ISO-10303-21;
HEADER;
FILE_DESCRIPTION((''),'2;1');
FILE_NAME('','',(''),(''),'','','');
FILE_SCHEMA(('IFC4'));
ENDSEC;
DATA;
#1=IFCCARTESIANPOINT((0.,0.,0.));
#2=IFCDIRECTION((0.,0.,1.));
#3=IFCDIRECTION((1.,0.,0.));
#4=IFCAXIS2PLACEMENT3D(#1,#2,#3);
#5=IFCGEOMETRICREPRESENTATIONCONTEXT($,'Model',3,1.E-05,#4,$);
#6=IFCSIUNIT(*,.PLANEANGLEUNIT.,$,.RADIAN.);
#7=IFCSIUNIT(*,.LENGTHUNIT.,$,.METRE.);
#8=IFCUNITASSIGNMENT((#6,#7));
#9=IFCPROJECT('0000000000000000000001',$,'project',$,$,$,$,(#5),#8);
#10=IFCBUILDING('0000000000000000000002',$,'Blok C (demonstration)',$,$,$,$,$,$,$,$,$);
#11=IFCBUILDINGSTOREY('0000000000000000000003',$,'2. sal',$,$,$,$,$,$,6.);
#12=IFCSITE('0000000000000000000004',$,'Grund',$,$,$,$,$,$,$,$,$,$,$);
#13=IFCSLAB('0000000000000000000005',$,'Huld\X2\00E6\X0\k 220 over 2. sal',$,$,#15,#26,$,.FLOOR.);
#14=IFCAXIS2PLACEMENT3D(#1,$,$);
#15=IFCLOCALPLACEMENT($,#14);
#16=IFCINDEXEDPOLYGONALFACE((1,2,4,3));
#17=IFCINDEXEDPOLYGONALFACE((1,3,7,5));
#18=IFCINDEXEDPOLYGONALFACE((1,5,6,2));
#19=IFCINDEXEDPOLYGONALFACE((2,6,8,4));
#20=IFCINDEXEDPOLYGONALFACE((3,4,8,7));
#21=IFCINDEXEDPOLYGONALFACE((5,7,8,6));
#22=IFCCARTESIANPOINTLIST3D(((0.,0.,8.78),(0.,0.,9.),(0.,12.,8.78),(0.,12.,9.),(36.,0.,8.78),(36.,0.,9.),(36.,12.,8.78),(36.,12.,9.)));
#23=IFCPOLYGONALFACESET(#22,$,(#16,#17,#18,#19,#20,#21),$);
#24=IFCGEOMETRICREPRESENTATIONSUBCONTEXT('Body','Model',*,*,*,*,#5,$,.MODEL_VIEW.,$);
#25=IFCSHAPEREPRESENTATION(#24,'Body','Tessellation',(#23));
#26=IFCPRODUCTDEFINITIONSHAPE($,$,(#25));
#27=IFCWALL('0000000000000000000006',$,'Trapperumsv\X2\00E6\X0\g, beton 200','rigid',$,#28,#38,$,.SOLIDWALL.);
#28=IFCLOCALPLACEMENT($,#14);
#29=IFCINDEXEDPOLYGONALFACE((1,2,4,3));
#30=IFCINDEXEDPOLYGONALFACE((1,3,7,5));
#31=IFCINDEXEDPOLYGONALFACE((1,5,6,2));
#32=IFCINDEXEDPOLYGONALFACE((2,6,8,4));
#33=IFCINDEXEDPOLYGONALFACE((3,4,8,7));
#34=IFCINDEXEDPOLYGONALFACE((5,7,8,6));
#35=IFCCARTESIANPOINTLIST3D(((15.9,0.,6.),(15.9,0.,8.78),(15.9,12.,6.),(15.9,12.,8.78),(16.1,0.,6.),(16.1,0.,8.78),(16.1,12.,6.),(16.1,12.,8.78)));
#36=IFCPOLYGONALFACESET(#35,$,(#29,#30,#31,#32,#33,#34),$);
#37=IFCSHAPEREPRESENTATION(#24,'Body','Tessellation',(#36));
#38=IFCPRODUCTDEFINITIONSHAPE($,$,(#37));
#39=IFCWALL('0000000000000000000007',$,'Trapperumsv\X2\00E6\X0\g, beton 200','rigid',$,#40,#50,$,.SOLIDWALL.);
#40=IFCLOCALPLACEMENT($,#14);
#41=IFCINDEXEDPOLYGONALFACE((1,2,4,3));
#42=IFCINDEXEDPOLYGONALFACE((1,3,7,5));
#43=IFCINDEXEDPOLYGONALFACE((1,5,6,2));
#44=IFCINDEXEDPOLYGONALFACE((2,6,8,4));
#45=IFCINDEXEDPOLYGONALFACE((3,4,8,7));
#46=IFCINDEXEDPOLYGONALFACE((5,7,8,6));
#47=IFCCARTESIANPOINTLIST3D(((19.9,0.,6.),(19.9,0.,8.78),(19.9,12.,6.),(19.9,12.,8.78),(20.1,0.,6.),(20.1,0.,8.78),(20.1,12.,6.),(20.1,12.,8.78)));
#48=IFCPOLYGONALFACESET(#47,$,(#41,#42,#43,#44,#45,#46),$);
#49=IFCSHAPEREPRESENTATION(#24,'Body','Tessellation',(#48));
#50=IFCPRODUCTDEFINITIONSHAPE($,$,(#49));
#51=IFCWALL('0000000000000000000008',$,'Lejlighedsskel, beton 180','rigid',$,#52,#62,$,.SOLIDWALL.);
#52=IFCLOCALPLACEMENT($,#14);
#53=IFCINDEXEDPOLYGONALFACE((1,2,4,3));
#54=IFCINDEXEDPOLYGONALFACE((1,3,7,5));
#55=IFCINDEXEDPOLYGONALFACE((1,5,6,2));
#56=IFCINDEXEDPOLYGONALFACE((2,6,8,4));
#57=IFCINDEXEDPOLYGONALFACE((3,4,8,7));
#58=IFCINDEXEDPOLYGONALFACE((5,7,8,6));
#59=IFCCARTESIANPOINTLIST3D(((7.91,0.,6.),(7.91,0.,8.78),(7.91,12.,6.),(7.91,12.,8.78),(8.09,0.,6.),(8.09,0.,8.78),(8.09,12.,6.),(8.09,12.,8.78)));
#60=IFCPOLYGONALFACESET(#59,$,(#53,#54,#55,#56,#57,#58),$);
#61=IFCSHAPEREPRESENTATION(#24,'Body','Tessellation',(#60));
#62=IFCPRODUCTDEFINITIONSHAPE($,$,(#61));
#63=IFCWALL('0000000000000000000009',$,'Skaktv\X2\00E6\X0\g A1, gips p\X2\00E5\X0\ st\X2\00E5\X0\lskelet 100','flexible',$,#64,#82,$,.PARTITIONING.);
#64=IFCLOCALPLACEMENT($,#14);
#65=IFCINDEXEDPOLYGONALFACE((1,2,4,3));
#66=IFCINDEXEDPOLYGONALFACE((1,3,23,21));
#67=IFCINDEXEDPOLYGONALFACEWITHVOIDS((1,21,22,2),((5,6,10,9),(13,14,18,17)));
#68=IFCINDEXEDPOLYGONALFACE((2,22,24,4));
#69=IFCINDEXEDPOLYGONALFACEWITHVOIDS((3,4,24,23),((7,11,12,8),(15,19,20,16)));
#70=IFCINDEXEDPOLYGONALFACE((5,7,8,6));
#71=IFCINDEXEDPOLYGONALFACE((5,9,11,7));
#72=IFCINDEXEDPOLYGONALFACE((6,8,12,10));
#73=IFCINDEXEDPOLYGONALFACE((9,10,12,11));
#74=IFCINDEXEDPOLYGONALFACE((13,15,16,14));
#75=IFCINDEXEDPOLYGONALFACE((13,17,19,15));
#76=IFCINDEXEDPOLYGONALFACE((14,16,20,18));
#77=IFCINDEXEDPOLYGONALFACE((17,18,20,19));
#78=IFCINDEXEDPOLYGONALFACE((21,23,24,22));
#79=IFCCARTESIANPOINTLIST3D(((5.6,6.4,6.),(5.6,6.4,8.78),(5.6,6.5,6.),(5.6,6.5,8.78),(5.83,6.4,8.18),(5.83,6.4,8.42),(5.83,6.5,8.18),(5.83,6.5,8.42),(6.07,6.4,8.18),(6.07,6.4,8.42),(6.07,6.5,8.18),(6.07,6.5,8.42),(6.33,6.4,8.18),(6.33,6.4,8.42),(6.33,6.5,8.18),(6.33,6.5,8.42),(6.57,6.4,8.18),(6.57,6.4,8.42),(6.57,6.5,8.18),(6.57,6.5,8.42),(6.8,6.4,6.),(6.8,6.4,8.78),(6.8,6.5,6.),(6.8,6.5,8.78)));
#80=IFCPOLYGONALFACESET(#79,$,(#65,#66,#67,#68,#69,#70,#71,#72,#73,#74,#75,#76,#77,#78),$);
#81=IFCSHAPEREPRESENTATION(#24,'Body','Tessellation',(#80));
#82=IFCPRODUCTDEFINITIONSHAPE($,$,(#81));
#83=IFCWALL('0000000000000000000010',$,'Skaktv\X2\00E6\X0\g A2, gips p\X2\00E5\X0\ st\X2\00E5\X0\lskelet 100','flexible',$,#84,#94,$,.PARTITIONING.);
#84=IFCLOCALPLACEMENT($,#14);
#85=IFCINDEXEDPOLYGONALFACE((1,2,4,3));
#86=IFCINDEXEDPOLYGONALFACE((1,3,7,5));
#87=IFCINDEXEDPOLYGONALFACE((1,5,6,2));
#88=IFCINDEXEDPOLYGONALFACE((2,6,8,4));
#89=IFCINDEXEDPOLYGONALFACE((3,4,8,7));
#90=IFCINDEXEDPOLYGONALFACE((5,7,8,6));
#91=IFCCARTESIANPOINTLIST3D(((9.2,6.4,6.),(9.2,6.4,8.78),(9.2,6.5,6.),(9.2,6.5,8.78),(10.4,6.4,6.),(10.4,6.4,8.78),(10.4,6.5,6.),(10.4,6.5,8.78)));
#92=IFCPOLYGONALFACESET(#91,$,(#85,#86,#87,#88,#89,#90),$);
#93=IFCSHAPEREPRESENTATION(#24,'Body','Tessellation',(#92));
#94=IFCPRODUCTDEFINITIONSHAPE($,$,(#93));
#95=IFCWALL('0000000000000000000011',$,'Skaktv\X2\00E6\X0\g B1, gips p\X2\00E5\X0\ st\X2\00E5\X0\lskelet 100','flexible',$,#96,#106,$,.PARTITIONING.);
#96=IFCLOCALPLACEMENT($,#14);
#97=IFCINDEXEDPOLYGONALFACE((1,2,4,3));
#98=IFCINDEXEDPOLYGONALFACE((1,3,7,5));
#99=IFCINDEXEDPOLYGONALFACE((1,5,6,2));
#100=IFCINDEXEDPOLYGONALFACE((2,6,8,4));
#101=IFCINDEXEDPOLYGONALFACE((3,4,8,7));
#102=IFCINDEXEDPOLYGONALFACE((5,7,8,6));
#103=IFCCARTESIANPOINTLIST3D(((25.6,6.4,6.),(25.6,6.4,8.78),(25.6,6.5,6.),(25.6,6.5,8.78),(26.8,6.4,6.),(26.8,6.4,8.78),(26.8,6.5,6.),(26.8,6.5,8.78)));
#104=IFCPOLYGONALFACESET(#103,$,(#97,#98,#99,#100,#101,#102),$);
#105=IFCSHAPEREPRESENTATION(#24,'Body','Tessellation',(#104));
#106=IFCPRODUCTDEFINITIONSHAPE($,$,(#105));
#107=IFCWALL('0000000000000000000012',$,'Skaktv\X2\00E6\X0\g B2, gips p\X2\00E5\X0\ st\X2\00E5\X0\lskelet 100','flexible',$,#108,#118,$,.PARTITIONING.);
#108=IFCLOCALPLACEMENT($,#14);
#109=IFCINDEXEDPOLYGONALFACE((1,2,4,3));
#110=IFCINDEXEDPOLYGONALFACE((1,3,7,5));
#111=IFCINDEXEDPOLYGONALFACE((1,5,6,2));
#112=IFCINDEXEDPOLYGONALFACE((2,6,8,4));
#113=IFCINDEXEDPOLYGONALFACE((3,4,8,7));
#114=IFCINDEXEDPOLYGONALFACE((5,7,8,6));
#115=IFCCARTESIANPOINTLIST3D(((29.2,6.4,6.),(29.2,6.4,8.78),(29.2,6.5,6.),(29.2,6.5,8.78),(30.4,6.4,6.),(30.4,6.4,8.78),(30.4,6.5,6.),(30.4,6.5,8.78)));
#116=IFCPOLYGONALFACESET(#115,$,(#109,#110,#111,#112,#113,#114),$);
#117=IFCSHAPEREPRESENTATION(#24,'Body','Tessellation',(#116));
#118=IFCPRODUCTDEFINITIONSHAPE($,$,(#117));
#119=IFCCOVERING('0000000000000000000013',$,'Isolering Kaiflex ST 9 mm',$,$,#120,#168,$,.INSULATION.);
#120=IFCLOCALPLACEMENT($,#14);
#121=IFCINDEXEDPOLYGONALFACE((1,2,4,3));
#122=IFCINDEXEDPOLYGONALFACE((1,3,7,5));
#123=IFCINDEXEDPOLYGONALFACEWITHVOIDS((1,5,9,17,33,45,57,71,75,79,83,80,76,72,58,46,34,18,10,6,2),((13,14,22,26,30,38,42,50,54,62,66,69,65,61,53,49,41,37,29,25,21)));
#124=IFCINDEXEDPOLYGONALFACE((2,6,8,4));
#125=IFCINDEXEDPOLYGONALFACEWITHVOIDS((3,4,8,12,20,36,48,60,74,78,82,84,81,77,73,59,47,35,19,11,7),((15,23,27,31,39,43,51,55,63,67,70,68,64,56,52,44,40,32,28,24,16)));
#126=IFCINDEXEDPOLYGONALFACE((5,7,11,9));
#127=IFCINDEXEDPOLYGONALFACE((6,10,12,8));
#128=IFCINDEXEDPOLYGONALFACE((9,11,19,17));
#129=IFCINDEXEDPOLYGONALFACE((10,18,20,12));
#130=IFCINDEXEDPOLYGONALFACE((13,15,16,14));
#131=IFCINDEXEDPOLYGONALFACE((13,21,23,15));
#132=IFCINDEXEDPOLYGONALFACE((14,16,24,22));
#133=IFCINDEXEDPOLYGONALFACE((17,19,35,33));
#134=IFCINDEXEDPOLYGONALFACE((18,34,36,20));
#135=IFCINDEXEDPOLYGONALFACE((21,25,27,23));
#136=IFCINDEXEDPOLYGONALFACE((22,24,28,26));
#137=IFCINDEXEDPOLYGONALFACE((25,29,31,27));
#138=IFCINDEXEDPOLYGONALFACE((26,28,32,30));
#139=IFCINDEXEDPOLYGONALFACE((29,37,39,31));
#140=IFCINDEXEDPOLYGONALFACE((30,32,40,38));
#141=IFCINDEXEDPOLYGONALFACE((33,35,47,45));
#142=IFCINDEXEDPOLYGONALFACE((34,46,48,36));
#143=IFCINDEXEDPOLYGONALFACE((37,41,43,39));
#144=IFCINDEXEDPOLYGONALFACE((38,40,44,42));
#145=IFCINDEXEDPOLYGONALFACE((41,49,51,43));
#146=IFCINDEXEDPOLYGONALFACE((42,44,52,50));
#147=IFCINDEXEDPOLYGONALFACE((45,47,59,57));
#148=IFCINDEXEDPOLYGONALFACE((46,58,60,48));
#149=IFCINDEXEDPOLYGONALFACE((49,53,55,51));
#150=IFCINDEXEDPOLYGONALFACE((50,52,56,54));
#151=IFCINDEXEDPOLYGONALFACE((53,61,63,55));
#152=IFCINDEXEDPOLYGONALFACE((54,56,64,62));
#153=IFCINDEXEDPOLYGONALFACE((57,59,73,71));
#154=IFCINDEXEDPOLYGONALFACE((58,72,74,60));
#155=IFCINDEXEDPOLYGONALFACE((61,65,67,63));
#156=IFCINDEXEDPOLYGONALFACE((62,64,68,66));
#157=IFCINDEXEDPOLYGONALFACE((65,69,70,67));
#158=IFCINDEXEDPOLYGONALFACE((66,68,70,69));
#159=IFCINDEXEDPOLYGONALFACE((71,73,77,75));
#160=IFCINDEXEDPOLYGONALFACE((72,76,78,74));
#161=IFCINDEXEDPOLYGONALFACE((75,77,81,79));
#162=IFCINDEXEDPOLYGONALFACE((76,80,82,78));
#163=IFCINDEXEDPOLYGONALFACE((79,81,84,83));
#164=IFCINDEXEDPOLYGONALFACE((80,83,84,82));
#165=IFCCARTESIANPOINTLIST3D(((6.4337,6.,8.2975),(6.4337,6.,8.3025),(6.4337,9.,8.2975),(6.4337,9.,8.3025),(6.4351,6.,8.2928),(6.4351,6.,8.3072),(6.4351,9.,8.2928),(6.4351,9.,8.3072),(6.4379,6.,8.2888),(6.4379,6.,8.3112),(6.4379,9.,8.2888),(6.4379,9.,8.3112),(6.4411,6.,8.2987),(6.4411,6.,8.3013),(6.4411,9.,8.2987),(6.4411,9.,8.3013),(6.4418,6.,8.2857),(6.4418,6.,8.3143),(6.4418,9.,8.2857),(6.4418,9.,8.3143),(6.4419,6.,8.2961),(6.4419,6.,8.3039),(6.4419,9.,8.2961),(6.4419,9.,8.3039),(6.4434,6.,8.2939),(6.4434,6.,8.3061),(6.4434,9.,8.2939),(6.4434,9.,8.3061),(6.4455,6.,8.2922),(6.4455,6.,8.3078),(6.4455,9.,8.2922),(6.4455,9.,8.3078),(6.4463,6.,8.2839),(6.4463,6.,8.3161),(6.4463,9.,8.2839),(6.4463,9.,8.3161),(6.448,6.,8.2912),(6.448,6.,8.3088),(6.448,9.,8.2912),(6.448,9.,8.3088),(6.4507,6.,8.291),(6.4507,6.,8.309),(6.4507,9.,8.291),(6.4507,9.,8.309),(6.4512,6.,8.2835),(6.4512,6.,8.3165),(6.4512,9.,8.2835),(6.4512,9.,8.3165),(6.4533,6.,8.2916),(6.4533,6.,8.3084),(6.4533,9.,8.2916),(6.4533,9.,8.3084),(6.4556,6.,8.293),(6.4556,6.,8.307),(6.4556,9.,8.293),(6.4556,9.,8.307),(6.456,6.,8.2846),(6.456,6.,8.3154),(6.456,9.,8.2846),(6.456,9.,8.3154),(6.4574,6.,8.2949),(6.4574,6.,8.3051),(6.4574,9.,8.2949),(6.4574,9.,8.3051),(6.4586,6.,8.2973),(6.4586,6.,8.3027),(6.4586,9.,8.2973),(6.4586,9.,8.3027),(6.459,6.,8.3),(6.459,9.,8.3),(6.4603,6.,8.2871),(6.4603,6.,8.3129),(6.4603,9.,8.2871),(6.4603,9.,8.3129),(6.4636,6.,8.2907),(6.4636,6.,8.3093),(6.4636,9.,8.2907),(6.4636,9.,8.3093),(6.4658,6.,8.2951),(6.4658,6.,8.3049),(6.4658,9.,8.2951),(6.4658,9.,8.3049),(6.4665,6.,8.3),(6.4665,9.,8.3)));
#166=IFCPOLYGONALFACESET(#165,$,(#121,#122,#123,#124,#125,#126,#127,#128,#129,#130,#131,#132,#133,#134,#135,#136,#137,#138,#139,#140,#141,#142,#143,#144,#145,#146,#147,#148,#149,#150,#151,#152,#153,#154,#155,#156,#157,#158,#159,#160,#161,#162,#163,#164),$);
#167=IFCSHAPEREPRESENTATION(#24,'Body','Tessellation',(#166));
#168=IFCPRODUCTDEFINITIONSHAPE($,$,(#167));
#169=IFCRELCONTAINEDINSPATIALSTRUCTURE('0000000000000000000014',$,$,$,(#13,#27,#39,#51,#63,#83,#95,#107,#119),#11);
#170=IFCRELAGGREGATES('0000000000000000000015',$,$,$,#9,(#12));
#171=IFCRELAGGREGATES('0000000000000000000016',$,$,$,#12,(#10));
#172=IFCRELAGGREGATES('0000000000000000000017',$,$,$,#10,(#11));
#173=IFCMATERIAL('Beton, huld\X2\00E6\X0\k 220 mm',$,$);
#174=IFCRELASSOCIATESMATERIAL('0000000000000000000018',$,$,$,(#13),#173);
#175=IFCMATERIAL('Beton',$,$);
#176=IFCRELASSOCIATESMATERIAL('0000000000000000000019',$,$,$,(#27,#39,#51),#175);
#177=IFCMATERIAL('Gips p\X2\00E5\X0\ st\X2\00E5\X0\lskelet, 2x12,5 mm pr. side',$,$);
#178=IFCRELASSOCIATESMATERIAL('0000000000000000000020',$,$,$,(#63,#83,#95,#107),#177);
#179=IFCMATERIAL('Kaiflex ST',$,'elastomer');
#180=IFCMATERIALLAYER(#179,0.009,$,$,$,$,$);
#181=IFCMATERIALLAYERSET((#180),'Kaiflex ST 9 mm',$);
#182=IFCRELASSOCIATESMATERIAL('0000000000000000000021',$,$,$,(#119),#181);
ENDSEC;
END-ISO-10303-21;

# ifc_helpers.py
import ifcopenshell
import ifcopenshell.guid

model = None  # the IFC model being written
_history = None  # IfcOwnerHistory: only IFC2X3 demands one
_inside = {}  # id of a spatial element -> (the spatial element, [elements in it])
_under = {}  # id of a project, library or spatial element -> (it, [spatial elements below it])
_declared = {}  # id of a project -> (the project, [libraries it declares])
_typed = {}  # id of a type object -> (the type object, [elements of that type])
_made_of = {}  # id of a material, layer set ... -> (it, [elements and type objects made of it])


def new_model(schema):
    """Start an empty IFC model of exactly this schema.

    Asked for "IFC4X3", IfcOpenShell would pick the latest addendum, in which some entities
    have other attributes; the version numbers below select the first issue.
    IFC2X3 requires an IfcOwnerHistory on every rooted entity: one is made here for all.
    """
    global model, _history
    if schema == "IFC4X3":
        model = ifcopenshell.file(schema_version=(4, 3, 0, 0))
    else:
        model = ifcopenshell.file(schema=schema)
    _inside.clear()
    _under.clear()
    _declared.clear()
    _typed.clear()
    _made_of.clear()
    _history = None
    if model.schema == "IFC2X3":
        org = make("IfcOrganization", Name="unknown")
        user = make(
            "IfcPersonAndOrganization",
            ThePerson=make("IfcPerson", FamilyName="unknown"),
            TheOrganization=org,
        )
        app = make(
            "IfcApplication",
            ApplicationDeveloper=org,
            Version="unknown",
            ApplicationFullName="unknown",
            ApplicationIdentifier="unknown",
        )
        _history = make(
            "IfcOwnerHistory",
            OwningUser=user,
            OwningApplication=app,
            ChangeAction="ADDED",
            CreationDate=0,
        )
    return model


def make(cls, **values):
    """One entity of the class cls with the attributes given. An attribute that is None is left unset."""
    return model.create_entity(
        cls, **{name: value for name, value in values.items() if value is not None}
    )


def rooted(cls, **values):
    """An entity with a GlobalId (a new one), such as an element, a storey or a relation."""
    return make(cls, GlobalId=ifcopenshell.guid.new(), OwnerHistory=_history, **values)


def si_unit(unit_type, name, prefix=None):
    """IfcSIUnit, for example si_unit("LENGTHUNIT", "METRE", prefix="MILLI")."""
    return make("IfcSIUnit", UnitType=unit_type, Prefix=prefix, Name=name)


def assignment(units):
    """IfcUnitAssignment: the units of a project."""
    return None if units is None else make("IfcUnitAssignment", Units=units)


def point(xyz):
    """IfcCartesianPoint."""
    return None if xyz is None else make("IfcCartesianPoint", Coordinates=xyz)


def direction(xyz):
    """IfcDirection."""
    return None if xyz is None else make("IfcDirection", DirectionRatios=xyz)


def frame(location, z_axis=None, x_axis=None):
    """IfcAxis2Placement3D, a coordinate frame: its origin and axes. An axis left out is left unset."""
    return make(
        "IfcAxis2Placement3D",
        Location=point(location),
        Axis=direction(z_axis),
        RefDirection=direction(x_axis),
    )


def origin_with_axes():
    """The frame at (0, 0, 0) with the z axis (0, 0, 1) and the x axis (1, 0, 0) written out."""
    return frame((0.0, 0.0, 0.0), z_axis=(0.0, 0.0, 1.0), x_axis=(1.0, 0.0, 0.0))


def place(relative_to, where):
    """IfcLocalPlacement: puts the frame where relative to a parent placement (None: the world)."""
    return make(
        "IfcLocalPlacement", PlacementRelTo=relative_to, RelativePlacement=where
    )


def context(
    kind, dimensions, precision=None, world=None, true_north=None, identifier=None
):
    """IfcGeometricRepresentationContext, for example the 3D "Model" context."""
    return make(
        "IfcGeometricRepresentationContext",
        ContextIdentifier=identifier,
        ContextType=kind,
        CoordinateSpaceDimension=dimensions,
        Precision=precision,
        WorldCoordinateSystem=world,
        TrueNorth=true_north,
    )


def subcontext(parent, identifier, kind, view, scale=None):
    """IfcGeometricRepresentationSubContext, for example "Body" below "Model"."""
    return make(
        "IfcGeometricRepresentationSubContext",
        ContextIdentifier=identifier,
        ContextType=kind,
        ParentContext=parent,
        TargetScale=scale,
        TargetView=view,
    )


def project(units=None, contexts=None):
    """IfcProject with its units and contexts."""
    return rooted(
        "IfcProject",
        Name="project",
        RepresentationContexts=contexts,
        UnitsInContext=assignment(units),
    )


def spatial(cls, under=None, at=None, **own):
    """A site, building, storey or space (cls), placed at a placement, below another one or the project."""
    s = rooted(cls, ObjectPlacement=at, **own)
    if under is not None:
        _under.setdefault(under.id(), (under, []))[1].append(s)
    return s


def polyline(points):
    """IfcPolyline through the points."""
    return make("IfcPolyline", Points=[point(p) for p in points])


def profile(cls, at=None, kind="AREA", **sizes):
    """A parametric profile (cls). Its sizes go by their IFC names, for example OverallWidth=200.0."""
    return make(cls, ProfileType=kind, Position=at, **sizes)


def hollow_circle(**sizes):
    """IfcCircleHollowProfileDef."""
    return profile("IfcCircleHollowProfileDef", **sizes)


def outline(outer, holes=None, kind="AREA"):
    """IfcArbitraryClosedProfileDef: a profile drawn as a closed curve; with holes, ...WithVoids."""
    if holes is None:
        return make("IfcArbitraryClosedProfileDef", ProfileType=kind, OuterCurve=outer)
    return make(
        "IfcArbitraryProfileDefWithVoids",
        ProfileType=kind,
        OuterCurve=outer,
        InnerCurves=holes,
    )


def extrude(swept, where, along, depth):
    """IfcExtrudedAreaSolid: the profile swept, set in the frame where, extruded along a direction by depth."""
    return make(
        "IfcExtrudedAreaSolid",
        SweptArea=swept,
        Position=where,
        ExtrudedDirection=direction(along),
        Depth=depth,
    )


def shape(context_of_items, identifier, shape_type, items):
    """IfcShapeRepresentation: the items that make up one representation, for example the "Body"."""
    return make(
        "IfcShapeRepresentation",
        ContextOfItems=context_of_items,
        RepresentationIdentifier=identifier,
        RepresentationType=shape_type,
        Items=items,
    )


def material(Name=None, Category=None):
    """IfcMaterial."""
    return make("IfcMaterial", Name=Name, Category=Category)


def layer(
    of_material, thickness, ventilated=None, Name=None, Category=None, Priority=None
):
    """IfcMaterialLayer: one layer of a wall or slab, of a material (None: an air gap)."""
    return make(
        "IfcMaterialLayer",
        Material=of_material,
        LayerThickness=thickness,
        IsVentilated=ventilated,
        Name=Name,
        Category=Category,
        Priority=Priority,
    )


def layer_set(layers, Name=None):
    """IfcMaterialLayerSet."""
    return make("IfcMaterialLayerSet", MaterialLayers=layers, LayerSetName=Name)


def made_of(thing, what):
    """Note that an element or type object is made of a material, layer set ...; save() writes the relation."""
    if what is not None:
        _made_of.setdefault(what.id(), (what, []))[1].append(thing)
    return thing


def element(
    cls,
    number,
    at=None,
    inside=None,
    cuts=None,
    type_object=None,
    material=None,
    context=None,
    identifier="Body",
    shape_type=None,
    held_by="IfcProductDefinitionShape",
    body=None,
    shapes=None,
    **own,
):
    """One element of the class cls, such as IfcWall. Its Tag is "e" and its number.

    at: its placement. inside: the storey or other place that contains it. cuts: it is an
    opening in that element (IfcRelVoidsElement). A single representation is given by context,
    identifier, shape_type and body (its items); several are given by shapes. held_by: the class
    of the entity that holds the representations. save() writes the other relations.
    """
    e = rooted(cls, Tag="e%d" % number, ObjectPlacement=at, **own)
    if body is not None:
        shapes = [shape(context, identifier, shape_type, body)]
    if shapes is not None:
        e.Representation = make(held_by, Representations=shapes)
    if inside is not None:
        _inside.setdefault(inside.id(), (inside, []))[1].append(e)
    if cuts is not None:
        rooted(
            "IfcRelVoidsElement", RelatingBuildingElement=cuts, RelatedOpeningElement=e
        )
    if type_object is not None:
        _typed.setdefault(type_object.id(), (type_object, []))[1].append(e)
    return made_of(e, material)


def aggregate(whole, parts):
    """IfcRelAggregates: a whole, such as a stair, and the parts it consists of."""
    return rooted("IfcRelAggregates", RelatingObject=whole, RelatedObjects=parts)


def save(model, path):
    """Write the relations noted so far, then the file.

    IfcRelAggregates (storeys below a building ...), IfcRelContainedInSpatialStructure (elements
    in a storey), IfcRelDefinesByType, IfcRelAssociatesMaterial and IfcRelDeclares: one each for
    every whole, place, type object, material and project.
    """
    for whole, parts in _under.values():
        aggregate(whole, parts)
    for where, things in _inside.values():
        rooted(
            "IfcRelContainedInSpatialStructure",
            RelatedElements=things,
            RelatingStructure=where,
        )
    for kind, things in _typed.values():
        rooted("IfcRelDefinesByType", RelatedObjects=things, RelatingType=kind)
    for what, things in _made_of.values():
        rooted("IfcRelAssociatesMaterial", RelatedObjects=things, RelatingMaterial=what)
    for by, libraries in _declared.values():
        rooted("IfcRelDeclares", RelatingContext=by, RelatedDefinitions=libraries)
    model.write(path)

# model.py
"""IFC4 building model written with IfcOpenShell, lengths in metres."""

from ifc_helpers import new_model, si_unit, frame, origin_with_axes, place, context, subcontext, project, spatial, polyline, hollow_circle, outline, extrude, material, layer, layer_set, element, save


model = new_model("IFC4")

# Units and contexts
model_context = context("Model", 3, precision=1e-05, world=origin_with_axes())
body_context = subcontext(model_context, "Body", "Model", "MODEL_VIEW")
ifc_project = project(units=[si_unit("PLANEANGLEUNIT", "RADIAN"), si_unit("LENGTHUNIT", "METRE")], contexts=[model_context])

# Site, building, storey
site = spatial("IfcSite", under=ifc_project, Name="Grund")
building = spatial("IfcBuilding", under=site, Name="Blok C (demonstration)")
storey = spatial("IfcBuildingStorey", under=building, Name="2. sal", Elevation=6.0)

# Slab
ifc_material_1 = material(Name="Beton, huldæk 220 mm")
slab_placement = place(None, origin_with_axes())
element("IfcSlab", 1, at=slab_placement, inside=storey, material=ifc_material_1, Name="Huldæk 220 over 2. sal", PredefinedType="FLOOR", context=body_context, shape_type="SweptSolid", body=[
    extrude(outline(polyline([(0.0, 0.0), (36.0, 0.0), (36.0, 12.0), (0.0, 12.0), (0.0, 0.0)])), frame((0.0, 0.0, 8.78)), (0.0, 0.0, 1.0), 0.22),
])

# Walls
ifc_material_2 = material(Name="Beton")
wall_1_placement = place(None, origin_with_axes())
element("IfcWall", 2, at=wall_1_placement, inside=storey, material=ifc_material_2, Name="Trapperumsvæg, beton 200", Description="rigid", PredefinedType="SOLIDWALL", context=body_context, shape_type="SweptSolid", body=[
    extrude(outline(polyline([(15.9, 0.0), (16.1, 0.0), (16.1, 12.0), (15.9, 12.0), (15.9, 0.0)])), frame((0.0, 0.0, 6.0)), (0.0, 0.0, 1.0), 2.78),
])
wall_2_placement = place(None, origin_with_axes())
element("IfcWall", 3, at=wall_2_placement, inside=storey, material=ifc_material_2, Name="Trapperumsvæg, beton 200", Description="rigid", PredefinedType="SOLIDWALL", context=body_context, shape_type="SweptSolid", body=[
    extrude(outline(polyline([(19.9, 0.0), (20.1, 0.0), (20.1, 12.0), (19.9, 12.0), (19.9, 0.0)])), frame((0.0, 0.0, 6.0)), (0.0, 0.0, 1.0), 2.78),
])
wall_3_placement = place(None, origin_with_axes())
element("IfcWall", 4, at=wall_3_placement, inside=storey, material=ifc_material_2, Name="Lejlighedsskel, beton 180", Description="rigid", PredefinedType="SOLIDWALL", context=body_context, shape_type="SweptSolid", body=[
    extrude(outline(polyline([(7.91, 0.0), (8.09, 0.0), (8.09, 12.0), (7.91, 12.0), (7.91, 0.0)])), frame((0.0, 0.0, 6.0)), (0.0, 0.0, 1.0), 2.78),
])

# Wall, openings
ifc_material_3 = material(Name="Gips på stålskelet, 2x12,5 mm pr. side")
wall_4_placement = place(None, origin_with_axes())
wall_4 = element("IfcWall", 5, at=wall_4_placement, inside=storey, material=ifc_material_3, Name="Skaktvæg A1, gips på stålskelet 100", Description="flexible", PredefinedType="PARTITIONING", context=body_context, shape_type="SweptSolid", body=[
    extrude(outline(polyline([(5.6, 6.4), (6.8, 6.4), (6.8, 6.5), (5.6, 6.5), (5.6, 6.4)])), frame((0.0, 0.0, 6.0)), (0.0, 0.0, 1.0), 2.78),
])
opening_1_placement = place(wall_4_placement, origin_with_axes())
element("IfcOpeningElement", 6, at=opening_1_placement, cuts=wall_4, PredefinedType="OPENING", context=body_context, shape_type="SweptSolid", body=[
    extrude(outline(polyline([(5.83, 6.33), (6.07, 6.33), (6.07, 6.57), (5.83, 6.57), (5.83, 6.33)])), frame((0.0, 0.0, 8.18)), (0.0, 0.0, 1.0), 0.24),
])
opening_2_placement = place(wall_4_placement, origin_with_axes())
element("IfcOpeningElement", 7, at=opening_2_placement, cuts=wall_4, PredefinedType="OPENING", context=body_context, shape_type="SweptSolid", body=[
    extrude(outline(polyline([(6.33, 6.33), (6.57, 6.33), (6.57, 6.57), (6.33, 6.57), (6.33, 6.33)])), frame((0.0, 0.0, 8.18)), (0.0, 0.0, 1.0), 0.24),
])

# Walls
wall_5_placement = place(None, origin_with_axes())
element("IfcWall", 8, at=wall_5_placement, inside=storey, material=ifc_material_3, Name="Skaktvæg A2, gips på stålskelet 100", Description="flexible", PredefinedType="PARTITIONING", context=body_context, shape_type="SweptSolid", body=[
    extrude(outline(polyline([(9.2, 6.4), (10.4, 6.4), (10.4, 6.5), (9.2, 6.5), (9.2, 6.4)])), frame((0.0, 0.0, 6.0)), (0.0, 0.0, 1.0), 2.78),
])
wall_6_placement = place(None, origin_with_axes())
element("IfcWall", 9, at=wall_6_placement, inside=storey, material=ifc_material_3, Name="Skaktvæg B1, gips på stålskelet 100", Description="flexible", PredefinedType="PARTITIONING", context=body_context, shape_type="SweptSolid", body=[
    extrude(outline(polyline([(25.6, 6.4), (26.8, 6.4), (26.8, 6.5), (25.6, 6.5), (25.6, 6.4)])), frame((0.0, 0.0, 6.0)), (0.0, 0.0, 1.0), 2.78),
])
wall_7_placement = place(None, origin_with_axes())
element("IfcWall", 10, at=wall_7_placement, inside=storey, material=ifc_material_3, Name="Skaktvæg B2, gips på stålskelet 100", Description="flexible", PredefinedType="PARTITIONING", context=body_context, shape_type="SweptSolid", body=[
    extrude(outline(polyline([(29.2, 6.4), (30.4, 6.4), (30.4, 6.5), (29.2, 6.5), (29.2, 6.4)])), frame((0.0, 0.0, 6.0)), (0.0, 0.0, 1.0), 2.78),
])

# Covering
ifc_material_4 = material(Name="Kaiflex ST", Category="elastomer")
ifc_layer = layer(ifc_material_4, 0.009)
ifc_layer_set = layer_set([ifc_layer], Name="Kaiflex ST 9 mm")
covering_placement = place(None, origin_with_axes())
element("IfcCovering", 11, at=covering_placement, inside=storey, material=ifc_layer_set, Name="Isolering Kaiflex ST 9 mm", PredefinedType="INSULATION", context=body_context, shape_type="SweptSolid", body=[
    extrude(hollow_circle(Radius=0.0165, WallThickness=0.0075), frame((6.45, 6.0, 8.3), z_axis=(0.0, 1.0, 0.0), x_axis=(1.0, 0.0, 0.0)), (0.0, 0.0, 1.0), 3.0),
])

save(model, "model.ifc")
